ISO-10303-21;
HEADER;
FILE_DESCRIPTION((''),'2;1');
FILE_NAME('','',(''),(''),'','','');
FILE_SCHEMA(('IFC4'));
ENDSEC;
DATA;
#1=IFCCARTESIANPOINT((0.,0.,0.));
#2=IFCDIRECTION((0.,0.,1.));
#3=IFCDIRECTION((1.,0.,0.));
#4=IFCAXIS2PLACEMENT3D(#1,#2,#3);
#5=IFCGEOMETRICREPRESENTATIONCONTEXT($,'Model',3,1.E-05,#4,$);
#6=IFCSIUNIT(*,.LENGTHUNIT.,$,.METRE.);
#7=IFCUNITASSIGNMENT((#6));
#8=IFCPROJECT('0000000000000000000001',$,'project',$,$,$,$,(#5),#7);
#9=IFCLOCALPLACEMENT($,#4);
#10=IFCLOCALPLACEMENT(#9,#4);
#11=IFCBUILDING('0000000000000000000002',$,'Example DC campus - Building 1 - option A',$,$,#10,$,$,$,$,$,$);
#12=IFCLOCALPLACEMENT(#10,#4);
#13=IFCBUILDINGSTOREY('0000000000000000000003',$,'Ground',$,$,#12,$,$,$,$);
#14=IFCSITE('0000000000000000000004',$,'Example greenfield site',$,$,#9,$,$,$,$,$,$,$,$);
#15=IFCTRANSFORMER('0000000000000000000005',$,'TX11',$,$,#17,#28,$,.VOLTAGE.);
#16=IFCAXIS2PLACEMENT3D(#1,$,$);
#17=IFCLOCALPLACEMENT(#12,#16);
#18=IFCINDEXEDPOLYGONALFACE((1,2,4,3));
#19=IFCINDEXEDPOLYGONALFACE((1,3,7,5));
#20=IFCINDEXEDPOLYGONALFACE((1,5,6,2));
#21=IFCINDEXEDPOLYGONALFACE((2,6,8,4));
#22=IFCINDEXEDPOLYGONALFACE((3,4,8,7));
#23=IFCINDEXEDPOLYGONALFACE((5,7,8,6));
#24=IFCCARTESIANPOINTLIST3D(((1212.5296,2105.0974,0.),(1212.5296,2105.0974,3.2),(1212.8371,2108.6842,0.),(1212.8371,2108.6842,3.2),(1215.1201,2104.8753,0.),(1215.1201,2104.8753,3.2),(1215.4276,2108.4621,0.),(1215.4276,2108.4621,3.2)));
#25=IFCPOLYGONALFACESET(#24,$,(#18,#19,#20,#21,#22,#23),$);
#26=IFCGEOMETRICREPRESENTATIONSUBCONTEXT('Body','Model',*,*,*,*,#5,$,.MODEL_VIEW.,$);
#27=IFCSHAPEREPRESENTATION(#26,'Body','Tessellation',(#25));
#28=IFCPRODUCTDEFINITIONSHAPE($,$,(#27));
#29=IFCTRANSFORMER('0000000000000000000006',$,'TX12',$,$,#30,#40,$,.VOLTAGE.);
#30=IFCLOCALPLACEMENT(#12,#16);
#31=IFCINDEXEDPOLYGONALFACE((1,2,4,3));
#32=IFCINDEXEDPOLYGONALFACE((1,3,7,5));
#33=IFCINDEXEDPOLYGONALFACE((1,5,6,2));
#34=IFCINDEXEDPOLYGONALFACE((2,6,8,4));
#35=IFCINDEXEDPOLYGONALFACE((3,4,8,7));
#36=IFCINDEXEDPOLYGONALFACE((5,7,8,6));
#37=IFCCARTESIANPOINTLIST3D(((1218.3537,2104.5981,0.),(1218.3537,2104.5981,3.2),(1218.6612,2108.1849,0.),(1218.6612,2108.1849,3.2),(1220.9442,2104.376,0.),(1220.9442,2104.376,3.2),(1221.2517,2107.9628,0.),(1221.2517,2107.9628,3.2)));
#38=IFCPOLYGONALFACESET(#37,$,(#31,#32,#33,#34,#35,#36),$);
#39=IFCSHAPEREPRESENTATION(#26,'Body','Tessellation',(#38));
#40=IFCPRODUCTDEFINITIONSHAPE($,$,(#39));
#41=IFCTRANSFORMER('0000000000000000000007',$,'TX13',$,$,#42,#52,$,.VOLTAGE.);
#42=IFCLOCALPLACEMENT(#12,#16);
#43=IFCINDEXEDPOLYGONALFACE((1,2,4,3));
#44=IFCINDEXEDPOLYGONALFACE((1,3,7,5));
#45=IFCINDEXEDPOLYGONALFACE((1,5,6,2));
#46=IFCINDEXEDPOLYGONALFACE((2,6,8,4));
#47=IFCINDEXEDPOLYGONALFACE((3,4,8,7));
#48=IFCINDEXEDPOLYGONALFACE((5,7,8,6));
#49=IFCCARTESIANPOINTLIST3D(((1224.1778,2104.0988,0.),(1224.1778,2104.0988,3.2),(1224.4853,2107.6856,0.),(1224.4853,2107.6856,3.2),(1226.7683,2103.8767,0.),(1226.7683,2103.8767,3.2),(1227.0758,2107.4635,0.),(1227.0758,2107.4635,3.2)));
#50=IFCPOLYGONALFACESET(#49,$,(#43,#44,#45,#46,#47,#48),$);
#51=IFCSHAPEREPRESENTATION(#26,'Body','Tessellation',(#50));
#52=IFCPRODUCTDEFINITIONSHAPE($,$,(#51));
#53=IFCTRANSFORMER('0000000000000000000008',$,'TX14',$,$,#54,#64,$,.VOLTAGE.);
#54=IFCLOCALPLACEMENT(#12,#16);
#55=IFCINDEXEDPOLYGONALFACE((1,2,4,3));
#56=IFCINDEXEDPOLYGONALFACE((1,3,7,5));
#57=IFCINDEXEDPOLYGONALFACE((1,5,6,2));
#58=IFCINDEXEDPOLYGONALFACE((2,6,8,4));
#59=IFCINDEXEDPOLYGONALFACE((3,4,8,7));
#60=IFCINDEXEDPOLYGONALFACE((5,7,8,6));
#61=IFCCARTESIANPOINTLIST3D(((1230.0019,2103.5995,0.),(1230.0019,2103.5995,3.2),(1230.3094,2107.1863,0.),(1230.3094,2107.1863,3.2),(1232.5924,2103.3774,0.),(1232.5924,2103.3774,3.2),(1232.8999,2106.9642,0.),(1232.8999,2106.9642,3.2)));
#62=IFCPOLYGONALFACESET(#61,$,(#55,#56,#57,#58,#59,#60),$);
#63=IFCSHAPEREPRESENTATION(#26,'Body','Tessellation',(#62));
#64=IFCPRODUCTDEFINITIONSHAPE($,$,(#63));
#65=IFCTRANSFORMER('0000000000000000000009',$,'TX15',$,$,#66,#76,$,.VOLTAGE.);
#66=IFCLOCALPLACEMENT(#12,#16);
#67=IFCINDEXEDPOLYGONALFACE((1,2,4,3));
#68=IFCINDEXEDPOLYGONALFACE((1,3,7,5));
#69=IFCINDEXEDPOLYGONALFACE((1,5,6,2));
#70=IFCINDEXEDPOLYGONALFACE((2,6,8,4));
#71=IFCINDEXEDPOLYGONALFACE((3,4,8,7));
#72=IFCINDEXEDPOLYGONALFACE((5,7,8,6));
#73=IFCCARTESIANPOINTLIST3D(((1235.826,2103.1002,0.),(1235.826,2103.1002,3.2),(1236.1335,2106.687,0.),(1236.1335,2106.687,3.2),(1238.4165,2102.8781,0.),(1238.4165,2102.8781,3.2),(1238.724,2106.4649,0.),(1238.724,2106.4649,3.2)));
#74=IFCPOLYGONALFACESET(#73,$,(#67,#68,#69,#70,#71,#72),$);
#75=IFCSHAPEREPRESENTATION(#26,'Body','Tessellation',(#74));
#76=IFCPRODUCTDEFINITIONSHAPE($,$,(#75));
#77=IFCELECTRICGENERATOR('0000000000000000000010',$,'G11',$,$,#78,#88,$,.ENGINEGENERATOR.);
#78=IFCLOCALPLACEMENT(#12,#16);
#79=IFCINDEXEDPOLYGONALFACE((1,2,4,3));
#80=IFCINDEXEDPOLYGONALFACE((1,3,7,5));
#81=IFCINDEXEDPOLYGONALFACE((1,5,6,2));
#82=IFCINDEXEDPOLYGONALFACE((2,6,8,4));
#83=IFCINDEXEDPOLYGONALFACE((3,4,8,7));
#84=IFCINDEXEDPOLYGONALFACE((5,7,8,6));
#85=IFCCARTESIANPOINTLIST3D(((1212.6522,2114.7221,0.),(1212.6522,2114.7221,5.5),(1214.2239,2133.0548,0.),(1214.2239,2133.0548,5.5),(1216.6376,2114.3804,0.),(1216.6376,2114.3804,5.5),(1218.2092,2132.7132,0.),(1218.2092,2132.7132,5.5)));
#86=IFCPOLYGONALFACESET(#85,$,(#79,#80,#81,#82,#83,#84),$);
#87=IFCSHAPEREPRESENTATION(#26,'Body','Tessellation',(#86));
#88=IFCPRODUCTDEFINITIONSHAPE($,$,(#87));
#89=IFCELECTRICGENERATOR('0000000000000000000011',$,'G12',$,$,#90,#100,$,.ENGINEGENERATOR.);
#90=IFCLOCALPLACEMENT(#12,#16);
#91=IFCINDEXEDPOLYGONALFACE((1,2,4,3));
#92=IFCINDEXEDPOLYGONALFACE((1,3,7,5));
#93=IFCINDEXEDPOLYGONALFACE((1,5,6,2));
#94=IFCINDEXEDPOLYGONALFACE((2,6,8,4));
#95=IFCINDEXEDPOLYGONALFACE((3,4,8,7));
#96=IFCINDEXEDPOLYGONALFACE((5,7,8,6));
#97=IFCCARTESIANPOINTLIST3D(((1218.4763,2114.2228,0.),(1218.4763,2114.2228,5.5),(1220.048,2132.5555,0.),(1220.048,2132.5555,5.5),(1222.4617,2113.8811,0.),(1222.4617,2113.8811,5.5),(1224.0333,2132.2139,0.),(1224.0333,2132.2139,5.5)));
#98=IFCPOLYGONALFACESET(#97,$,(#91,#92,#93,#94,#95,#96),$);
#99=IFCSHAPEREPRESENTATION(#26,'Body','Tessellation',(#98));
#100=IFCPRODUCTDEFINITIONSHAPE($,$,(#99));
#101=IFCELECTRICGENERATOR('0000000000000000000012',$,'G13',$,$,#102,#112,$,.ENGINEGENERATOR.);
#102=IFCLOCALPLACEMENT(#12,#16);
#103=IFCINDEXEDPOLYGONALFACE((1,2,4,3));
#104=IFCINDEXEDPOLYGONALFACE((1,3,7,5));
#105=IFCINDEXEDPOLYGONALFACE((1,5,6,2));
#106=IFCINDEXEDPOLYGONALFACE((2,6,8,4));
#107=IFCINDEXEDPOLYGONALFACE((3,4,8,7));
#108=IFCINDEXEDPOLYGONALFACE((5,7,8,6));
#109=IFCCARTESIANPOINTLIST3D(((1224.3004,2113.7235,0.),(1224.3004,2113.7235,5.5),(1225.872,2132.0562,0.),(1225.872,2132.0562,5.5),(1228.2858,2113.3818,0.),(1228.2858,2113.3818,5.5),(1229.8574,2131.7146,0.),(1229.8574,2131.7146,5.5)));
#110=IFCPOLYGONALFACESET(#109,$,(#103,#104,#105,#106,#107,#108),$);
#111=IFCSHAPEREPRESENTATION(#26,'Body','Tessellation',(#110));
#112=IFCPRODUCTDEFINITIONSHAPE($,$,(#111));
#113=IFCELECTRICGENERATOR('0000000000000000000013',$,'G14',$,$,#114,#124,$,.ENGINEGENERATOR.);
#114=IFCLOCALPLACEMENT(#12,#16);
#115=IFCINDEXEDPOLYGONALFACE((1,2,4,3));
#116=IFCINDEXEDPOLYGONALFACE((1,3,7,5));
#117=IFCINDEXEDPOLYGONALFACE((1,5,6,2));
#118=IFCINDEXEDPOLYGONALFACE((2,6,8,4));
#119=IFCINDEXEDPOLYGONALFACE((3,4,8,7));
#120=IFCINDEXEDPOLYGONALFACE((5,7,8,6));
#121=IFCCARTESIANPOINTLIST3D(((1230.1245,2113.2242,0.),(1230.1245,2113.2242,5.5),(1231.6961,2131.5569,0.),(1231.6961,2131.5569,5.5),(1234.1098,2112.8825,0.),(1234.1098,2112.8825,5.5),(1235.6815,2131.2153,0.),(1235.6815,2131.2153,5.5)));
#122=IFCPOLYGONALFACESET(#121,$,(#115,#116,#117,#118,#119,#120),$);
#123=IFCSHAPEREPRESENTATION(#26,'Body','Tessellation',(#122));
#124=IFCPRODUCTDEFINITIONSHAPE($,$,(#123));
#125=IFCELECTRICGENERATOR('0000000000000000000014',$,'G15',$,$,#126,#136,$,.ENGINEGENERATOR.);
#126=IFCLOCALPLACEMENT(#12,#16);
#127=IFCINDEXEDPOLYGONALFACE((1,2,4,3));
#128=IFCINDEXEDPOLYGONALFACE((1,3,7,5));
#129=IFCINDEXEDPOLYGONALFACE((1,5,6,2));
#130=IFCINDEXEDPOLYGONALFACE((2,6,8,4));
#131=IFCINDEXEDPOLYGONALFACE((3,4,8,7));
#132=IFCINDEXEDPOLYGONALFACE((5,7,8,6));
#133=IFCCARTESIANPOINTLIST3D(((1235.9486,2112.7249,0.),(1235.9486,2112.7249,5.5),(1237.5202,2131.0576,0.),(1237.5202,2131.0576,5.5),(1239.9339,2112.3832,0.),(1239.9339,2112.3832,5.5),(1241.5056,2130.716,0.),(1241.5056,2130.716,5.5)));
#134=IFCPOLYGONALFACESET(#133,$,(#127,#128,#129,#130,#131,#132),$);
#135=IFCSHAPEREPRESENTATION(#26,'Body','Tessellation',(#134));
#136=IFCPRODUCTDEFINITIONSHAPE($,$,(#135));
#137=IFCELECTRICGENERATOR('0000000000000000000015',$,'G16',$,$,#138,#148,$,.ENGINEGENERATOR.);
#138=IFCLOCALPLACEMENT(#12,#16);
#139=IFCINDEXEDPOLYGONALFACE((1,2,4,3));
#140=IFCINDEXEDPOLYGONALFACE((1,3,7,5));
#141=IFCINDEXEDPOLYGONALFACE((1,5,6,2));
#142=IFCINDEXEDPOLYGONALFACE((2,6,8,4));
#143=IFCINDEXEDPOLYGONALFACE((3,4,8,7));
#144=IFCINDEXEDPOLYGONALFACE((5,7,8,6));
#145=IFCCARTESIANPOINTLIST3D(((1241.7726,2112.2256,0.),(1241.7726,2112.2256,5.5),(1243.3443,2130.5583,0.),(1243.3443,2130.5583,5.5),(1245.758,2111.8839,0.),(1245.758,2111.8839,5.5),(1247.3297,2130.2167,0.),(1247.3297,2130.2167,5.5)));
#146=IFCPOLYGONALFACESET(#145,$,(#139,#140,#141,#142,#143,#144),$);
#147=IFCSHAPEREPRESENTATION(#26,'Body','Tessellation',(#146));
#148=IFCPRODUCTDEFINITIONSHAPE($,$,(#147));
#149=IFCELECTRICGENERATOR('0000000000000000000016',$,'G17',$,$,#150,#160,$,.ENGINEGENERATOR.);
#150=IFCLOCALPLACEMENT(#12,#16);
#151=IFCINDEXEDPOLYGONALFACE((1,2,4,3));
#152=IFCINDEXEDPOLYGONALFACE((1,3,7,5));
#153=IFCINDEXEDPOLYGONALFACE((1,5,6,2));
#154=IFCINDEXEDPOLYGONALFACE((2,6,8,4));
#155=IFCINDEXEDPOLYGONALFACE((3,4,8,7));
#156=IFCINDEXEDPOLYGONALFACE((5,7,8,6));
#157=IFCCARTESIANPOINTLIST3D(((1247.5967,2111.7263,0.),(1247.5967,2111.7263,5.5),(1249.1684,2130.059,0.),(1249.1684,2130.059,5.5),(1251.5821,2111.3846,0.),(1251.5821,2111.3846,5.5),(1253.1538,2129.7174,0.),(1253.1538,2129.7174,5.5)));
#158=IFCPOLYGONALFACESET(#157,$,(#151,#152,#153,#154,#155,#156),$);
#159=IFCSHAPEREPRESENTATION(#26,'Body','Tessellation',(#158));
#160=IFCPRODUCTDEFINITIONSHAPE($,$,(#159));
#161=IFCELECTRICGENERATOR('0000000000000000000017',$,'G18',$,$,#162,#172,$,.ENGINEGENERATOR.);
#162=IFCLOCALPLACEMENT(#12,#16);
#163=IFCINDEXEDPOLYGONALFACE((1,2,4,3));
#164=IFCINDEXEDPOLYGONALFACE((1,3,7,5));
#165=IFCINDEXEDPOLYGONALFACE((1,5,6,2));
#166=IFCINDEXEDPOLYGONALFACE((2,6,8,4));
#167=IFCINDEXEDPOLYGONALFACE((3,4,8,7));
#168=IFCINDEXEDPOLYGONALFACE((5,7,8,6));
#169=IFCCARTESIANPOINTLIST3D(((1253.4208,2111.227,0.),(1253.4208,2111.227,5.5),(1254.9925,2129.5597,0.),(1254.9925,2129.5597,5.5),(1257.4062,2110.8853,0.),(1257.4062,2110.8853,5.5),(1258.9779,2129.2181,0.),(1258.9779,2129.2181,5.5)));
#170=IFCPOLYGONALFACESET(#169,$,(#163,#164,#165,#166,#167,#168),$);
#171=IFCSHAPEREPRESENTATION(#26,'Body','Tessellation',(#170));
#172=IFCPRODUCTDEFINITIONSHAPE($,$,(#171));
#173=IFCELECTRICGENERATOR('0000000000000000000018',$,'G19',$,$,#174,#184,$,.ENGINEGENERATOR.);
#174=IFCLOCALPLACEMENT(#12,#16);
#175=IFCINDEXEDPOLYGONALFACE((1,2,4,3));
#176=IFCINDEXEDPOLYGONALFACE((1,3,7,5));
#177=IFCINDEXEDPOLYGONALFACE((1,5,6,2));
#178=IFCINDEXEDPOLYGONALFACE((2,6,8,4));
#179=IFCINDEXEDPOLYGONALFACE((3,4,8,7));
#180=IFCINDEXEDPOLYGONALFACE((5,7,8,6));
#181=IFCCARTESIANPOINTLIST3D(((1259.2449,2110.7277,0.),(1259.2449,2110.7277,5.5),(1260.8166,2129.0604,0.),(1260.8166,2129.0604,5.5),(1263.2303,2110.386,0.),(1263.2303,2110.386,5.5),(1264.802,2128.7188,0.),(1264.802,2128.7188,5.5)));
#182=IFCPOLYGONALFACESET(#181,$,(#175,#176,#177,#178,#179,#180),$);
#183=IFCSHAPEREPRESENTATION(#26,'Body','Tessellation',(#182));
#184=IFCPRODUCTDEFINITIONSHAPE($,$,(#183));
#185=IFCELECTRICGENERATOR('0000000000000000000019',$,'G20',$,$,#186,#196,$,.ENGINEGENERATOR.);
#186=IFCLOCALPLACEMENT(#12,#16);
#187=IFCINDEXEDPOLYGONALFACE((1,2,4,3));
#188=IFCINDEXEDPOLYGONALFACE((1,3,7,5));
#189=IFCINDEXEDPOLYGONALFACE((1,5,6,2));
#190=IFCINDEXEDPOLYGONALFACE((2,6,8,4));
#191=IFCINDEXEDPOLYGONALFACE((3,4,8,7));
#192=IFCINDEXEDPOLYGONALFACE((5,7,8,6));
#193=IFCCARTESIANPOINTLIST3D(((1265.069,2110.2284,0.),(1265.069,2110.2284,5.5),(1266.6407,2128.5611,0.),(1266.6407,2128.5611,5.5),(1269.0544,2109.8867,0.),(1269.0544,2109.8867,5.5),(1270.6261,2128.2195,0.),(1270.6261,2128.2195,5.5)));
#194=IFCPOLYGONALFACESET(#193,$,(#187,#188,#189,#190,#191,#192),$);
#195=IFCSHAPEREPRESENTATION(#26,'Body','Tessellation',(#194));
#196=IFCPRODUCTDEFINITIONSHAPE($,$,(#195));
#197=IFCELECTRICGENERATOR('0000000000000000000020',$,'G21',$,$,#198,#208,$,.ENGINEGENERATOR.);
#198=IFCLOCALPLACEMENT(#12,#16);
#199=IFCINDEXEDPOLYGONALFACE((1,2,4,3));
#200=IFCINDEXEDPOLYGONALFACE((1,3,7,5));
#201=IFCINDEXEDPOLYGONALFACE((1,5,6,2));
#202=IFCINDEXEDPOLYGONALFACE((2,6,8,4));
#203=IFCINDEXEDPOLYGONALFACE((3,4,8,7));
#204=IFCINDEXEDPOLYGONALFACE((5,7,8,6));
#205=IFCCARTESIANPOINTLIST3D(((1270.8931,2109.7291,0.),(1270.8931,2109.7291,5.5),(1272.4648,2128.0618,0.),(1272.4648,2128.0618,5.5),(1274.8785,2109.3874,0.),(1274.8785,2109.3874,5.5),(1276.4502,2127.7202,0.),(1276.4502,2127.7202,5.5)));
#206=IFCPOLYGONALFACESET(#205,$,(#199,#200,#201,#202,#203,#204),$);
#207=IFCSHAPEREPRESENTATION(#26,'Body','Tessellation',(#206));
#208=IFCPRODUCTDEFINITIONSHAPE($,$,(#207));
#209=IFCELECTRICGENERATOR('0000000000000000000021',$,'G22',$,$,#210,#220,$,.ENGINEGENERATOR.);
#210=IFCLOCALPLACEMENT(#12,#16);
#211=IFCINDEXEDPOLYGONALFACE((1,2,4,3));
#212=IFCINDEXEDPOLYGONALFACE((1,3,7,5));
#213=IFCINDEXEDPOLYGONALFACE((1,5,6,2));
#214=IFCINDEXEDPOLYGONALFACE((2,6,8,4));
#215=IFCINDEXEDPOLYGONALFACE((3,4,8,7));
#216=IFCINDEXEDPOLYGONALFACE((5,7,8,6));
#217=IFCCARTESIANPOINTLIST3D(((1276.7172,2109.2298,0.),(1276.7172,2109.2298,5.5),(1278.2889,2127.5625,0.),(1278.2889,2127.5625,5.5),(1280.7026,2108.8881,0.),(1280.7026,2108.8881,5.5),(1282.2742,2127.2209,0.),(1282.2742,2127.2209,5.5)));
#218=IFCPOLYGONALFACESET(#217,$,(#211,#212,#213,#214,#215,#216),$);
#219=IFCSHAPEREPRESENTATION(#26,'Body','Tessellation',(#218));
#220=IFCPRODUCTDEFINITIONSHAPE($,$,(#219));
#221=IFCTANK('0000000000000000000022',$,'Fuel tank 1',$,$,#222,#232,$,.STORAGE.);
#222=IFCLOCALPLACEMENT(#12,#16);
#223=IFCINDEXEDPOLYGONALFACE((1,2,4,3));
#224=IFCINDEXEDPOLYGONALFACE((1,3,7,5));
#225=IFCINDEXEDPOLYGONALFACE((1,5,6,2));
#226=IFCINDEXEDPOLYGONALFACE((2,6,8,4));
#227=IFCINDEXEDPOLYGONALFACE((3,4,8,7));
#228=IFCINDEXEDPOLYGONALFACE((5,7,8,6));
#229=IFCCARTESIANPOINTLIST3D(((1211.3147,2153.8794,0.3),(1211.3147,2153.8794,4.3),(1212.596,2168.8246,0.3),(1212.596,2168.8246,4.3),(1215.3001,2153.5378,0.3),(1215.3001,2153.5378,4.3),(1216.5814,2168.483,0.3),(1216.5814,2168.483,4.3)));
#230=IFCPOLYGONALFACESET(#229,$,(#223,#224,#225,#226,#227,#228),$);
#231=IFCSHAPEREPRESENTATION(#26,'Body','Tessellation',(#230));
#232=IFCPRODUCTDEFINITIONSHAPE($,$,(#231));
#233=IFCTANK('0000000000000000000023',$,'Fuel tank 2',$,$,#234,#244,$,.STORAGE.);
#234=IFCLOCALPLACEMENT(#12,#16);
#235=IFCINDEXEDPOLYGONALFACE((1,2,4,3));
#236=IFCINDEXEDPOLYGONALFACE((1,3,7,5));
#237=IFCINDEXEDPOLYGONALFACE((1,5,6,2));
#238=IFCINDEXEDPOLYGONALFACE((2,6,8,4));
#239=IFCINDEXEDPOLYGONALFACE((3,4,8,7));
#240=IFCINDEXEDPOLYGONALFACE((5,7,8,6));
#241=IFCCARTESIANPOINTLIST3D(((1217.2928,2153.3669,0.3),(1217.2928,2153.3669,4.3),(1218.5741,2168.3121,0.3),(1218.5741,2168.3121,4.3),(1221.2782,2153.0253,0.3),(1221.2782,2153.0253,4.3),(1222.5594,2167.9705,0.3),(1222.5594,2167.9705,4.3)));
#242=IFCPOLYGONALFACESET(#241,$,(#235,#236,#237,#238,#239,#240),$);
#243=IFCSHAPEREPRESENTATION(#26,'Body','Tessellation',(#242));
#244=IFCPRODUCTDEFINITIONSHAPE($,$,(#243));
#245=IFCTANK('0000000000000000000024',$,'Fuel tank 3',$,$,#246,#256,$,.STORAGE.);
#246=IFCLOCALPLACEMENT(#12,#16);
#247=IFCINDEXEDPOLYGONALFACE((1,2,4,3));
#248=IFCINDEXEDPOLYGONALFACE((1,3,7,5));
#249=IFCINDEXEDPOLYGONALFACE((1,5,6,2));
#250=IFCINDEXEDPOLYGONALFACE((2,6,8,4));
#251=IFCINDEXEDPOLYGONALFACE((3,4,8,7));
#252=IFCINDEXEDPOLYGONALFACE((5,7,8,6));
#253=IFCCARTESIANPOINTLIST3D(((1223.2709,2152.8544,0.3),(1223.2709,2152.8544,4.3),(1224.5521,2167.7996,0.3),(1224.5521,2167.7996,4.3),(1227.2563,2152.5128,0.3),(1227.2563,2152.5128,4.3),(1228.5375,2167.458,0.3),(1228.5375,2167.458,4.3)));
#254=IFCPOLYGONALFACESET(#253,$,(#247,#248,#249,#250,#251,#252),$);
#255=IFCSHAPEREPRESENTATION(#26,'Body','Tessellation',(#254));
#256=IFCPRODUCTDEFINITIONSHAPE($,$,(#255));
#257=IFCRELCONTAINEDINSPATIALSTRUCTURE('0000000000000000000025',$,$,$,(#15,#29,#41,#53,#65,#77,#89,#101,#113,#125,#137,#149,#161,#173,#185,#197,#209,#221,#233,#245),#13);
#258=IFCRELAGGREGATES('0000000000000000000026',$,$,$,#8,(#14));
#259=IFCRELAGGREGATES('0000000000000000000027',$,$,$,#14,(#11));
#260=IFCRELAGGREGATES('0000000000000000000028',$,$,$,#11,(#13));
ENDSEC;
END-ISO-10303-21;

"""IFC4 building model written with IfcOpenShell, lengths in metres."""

from ifc_helpers import new_model, si_unit, frame, origin_with_axes, place, context, subcontext, project, spatial, line, indexed_curve, outline, extrude, element, save


model = new_model("IFC4")

# Units and contexts
model_context = context("Model", 3, precision=1e-05, world=origin_with_axes())
body_context = subcontext(model_context, "Body", "Model", "MODEL_VIEW")
ifc_project = project(units=[si_unit("LENGTHUNIT", "METRE")], contexts=[model_context])

# Site, building, storey
site_placement = place(None, origin_with_axes())
site = spatial("IfcSite", under=ifc_project, at=site_placement, Name="Example greenfield site")
building_placement = place(site_placement, origin_with_axes())
building = spatial("IfcBuilding", under=site, at=building_placement, Name="Example DC campus - Building 1 - option A")
storey_placement = place(building_placement, origin_with_axes())
storey = spatial("IfcBuildingStorey", under=building, at=storey_placement, Name="Ground")

# Transformers
for number, where, z_axis, x_axis, name in (
    (1, (1212.5296, 2105.0974, 0.0), (0.0, 0.0, 1.0), (0.996345, -0.085417, 0.0), "TX11"),
    (2, (1218.3537, 2104.5981, 0.0), (0.0, 0.0, 1.0), (0.996345, -0.085417, 0.0), "TX12"),
    (3, (1224.1778, 2104.0988, 0.0), (0.0, 0.0, 1.0), (0.996345, -0.085417, 0.0), "TX13"),
    (4, (1230.0019, 2103.5995, 0.0), (0.0, 0.0, 1.0), (0.996345, -0.085417, 0.0), "TX14"),
    (5, (1235.826, 2103.1002, 0.0), (0.0, 0.0, 1.0), (0.996345, -0.085417, 0.0), "TX15"),
):
    element("IfcTransformer", number, at=place(storey_placement, frame(where, z_axis=z_axis, x_axis=x_axis)), inside=storey, Name=name, PredefinedType="VOLTAGE", context=body_context, shape_type="SweptSolid", body=[
        extrude(outline(indexed_curve([(0.0, 0.0), (2.6, 0.0), (2.6, 3.6), (0.0, 3.6)], segments=[line(1, 2, 3, 4, 1)])), origin_with_axes(), (0.0, 0.0, 1.0), 3.2),
    ])

# Electric generators
for number, where, z_axis, x_axis, name in (
    (6, (1212.6522, 2114.7221, 0.0), (0.0, 0.0, 1.0), (0.996345, -0.085417, 0.0), "G11"),
    (7, (1218.4763, 2114.2228, 0.0), (0.0, 0.0, 1.0), (0.996345, -0.085417, 0.0), "G12"),
    (8, (1224.3004, 2113.7235, 0.0), (0.0, 0.0, 1.0), (0.996345, -0.085417, 0.0), "G13"),
    (9, (1230.1245, 2113.2242, 0.0), (0.0, 0.0, 1.0), (0.996345, -0.085417, 0.0), "G14"),
    (10, (1235.9486, 2112.7249, 0.0), (0.0, 0.0, 1.0), (0.996345, -0.085417, 0.0), "G15"),
    (11, (1241.7726, 2112.2256, 0.0), (0.0, 0.0, 1.0), (0.996345, -0.085417, 0.0), "G16"),
    (12, (1247.5967, 2111.7263, 0.0), (0.0, 0.0, 1.0), (0.996345, -0.085417, 0.0), "G17"),
    (13, (1253.4208, 2111.227, 0.0), (0.0, 0.0, 1.0), (0.996345, -0.085417, 0.0), "G18"),
    (14, (1259.2449, 2110.7277, 0.0), (0.0, 0.0, 1.0), (0.996345, -0.085417, 0.0), "G19"),
    (15, (1265.069, 2110.2284, 0.0), (0.0, 0.0, 1.0), (0.996345, -0.085417, 0.0), "G20"),
    (16, (1270.8931, 2109.7291, 0.0), (0.0, 0.0, 1.0), (0.996345, -0.085417, 0.0), "G21"),
    (17, (1276.7172, 2109.2298, 0.0), (0.0, 0.0, 1.0), (0.996345, -0.085417, 0.0), "G22"),
):
    element("IfcElectricGenerator", number, at=place(storey_placement, frame(where, z_axis=z_axis, x_axis=x_axis)), inside=storey, Name=name, PredefinedType="ENGINEGENERATOR", context=body_context, shape_type="SweptSolid", body=[
        extrude(outline(indexed_curve([(0.0, 0.0), (4.0, 0.0), (4.0, 18.4), (0.0, 18.4)], segments=[line(1, 2, 3, 4, 1)])), origin_with_axes(), (0.0, 0.0, 1.0), 5.5),
    ])

# Tanks
for number, where, z_axis, x_axis, name in (
    (18, (1211.3147, 2153.8794, 0.3), (0.0, 0.0, 1.0), (0.996345, -0.085417, 0.0), "Fuel tank 1"),
    (19, (1217.2928, 2153.3669, 0.3), (0.0, 0.0, 1.0), (0.996345, -0.085417, 0.0), "Fuel tank 2"),
    (20, (1223.2709, 2152.8544, 0.3), (0.0, 0.0, 1.0), (0.996345, -0.085417, 0.0), "Fuel tank 3"),
):
    element("IfcTank", number, at=place(storey_placement, frame(where, z_axis=z_axis, x_axis=x_axis)), inside=storey, Name=name, PredefinedType="STORAGE", context=body_context, shape_type="SweptSolid", body=[
        extrude(outline(indexed_curve([(0.0, 0.0), (4.0, 0.0), (4.0, 15.0), (0.0, 15.0)], segments=[line(1, 2, 3, 4, 1)])), origin_with_axes(), (0.0, 0.0, 1.0), 4.0),
    ])

save(model, "model.ifc")
